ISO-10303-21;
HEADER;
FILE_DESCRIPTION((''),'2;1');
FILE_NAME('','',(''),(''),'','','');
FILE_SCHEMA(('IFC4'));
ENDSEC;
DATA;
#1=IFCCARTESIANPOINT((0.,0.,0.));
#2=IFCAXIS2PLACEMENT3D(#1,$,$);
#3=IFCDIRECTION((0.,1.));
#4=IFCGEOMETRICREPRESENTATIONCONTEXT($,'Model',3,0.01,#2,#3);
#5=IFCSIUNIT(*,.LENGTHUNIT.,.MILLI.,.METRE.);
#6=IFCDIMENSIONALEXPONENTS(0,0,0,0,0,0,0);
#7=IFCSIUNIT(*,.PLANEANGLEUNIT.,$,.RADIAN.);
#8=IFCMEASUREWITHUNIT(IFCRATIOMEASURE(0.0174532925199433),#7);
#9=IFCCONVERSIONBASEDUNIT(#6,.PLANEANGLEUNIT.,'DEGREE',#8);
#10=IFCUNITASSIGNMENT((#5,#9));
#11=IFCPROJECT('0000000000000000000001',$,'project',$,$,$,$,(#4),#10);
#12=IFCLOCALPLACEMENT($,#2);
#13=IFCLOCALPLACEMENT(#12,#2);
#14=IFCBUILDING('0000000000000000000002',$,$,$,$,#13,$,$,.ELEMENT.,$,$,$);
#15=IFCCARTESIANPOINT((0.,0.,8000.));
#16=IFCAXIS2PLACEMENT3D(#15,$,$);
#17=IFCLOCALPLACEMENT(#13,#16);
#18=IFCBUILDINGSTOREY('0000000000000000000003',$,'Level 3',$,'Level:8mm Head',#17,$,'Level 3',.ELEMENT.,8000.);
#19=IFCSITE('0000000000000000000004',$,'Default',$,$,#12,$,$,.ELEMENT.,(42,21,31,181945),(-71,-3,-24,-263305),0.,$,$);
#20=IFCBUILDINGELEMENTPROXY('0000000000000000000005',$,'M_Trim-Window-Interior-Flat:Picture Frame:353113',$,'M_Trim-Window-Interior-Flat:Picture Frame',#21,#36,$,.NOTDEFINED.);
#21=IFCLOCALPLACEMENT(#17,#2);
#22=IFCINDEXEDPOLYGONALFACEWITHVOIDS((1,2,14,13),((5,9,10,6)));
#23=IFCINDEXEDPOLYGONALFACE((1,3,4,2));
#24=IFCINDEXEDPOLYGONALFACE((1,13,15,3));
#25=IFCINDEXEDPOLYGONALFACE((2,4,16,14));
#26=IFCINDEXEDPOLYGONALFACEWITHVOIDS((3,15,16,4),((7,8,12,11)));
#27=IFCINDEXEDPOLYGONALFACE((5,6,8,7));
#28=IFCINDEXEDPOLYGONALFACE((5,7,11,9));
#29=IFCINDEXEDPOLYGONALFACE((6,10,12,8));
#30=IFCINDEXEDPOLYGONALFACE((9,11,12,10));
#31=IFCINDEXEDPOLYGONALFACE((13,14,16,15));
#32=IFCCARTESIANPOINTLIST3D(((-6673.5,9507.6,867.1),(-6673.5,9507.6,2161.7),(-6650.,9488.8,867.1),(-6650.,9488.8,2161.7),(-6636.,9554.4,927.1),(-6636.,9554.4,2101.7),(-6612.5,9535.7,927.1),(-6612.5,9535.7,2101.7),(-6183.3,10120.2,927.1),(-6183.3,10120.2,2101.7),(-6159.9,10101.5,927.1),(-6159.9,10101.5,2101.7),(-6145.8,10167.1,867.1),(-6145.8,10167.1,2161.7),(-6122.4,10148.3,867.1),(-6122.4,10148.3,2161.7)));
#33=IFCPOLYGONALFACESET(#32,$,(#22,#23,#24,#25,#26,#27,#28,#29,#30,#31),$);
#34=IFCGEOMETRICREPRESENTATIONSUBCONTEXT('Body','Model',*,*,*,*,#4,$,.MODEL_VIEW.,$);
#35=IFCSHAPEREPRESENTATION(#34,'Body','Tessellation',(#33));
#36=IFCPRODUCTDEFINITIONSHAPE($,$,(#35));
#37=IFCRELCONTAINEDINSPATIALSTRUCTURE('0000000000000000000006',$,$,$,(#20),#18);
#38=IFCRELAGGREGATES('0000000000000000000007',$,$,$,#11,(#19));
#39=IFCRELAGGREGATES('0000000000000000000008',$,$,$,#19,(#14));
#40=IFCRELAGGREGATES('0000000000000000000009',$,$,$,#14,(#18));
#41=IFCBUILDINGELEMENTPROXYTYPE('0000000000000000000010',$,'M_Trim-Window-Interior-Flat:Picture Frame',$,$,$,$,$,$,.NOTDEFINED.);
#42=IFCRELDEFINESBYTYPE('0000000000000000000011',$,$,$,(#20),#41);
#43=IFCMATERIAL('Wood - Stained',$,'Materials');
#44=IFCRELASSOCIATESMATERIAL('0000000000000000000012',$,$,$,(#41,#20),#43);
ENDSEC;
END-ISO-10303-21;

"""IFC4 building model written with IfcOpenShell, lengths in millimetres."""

from ifc_helpers import new_model, entity, si_unit, converted_unit, direction, frame, origin, place, context, subcontext, project, spatial, polyline, outline, extrude, source, transform, mapped, material, type_object, type_shapes, element, save


model = new_model("IFC4")

# Units and contexts
model_context = context("Model", 3, precision=0.01, world=origin(), true_north=direction((0.0, 1.0)))
body_context = subcontext(model_context, "Body", "Model", "MODEL_VIEW")
ifc_project = project(units=[si_unit("LENGTHUNIT", "METRE", prefix="MILLI"), converted_unit("PLANEANGLEUNIT", "DEGREE", entity("IfcRatioMeasure", 0.0174532925199433), si_unit("PLANEANGLEUNIT", "RADIAN"), dimensions=[0, 0, 0, 0, 0, 0, 0])], contexts=[model_context])

# Site, building, storey
site_placement = place(None, origin())
site = spatial("IfcSite", under=ifc_project, at=site_placement, Name="Default", CompositionType="ELEMENT", RefLatitude=(42, 21, 31, 181945), RefLongitude=(-71, -3, -24, -263305), RefElevation=0.0)
building_placement = place(site_placement, origin())
building = spatial("IfcBuilding", under=site, at=building_placement, CompositionType="ELEMENT")
storey_placement = place(building_placement, frame((0.0, 0.0, 8000.0)))
storey = spatial("IfcBuildingStorey", under=building, at=storey_placement, Name="Level 3", ObjectType="Level:8mm Head", LongName="Level 3", CompositionType="ELEMENT", Elevation=8000.0)

# Shared definitions
ifc_material_1 = material(Name="Wood - Stained", Category="Materials")

# Building element proxy
building_element_proxy_type_1 = type_object("IfcBuildingElementProxyType", Name="M_Trim-Window-Interior-Flat:Picture Frame", PredefinedType="NOTDEFINED", material=ifc_material_1)
shared_shape_1 = source(origin(), body_context, "Body", "SweptSolid", [
    extrude(outline(polyline([(-422.3, -647.3), (422.3, -647.3), (422.3, 647.3), (-422.3, 647.3), (-422.3, -647.3)]), holes=[polyline([(-362.3, -587.3), (-362.3, 587.3), (362.3, 587.3), (362.3, -587.3), (-362.3, -587.3)])]), frame((0.0, -600.0, 0.0), z_axis=(0.0, 0.0, 1.0), x_axis=(-1.0, 0.0, 0.0)), (0.0, 0.0, 1.0), 30.0),
])
type_shapes(building_element_proxy_type_1, [shared_shape_1])
for number, where, z_axis, x_axis, name in (
    (1, (-6386.2, 9818.6, 2114.4), (-0.780869, 0.624695, 0.0), (-0.624695, -0.780869, 0.0), "M_Trim-Window-Interior-Flat:Picture Frame:353113"),
):
    element("IfcBuildingElementProxy", number, at=place(storey_placement, frame(where, z_axis=z_axis, x_axis=x_axis)), inside=storey, type_object=building_element_proxy_type_1, material=ifc_material_1, Name=name, ObjectType="M_Trim-Window-Interior-Flat:Picture Frame", PredefinedType="NOTDEFINED", context=body_context, shape_type="MappedRepresentation", body=[
        mapped(shared_shape_1, transform((0.0, 0.0, 0.0), scale=1.0)),
    ])

save(model, "model.ifc")
